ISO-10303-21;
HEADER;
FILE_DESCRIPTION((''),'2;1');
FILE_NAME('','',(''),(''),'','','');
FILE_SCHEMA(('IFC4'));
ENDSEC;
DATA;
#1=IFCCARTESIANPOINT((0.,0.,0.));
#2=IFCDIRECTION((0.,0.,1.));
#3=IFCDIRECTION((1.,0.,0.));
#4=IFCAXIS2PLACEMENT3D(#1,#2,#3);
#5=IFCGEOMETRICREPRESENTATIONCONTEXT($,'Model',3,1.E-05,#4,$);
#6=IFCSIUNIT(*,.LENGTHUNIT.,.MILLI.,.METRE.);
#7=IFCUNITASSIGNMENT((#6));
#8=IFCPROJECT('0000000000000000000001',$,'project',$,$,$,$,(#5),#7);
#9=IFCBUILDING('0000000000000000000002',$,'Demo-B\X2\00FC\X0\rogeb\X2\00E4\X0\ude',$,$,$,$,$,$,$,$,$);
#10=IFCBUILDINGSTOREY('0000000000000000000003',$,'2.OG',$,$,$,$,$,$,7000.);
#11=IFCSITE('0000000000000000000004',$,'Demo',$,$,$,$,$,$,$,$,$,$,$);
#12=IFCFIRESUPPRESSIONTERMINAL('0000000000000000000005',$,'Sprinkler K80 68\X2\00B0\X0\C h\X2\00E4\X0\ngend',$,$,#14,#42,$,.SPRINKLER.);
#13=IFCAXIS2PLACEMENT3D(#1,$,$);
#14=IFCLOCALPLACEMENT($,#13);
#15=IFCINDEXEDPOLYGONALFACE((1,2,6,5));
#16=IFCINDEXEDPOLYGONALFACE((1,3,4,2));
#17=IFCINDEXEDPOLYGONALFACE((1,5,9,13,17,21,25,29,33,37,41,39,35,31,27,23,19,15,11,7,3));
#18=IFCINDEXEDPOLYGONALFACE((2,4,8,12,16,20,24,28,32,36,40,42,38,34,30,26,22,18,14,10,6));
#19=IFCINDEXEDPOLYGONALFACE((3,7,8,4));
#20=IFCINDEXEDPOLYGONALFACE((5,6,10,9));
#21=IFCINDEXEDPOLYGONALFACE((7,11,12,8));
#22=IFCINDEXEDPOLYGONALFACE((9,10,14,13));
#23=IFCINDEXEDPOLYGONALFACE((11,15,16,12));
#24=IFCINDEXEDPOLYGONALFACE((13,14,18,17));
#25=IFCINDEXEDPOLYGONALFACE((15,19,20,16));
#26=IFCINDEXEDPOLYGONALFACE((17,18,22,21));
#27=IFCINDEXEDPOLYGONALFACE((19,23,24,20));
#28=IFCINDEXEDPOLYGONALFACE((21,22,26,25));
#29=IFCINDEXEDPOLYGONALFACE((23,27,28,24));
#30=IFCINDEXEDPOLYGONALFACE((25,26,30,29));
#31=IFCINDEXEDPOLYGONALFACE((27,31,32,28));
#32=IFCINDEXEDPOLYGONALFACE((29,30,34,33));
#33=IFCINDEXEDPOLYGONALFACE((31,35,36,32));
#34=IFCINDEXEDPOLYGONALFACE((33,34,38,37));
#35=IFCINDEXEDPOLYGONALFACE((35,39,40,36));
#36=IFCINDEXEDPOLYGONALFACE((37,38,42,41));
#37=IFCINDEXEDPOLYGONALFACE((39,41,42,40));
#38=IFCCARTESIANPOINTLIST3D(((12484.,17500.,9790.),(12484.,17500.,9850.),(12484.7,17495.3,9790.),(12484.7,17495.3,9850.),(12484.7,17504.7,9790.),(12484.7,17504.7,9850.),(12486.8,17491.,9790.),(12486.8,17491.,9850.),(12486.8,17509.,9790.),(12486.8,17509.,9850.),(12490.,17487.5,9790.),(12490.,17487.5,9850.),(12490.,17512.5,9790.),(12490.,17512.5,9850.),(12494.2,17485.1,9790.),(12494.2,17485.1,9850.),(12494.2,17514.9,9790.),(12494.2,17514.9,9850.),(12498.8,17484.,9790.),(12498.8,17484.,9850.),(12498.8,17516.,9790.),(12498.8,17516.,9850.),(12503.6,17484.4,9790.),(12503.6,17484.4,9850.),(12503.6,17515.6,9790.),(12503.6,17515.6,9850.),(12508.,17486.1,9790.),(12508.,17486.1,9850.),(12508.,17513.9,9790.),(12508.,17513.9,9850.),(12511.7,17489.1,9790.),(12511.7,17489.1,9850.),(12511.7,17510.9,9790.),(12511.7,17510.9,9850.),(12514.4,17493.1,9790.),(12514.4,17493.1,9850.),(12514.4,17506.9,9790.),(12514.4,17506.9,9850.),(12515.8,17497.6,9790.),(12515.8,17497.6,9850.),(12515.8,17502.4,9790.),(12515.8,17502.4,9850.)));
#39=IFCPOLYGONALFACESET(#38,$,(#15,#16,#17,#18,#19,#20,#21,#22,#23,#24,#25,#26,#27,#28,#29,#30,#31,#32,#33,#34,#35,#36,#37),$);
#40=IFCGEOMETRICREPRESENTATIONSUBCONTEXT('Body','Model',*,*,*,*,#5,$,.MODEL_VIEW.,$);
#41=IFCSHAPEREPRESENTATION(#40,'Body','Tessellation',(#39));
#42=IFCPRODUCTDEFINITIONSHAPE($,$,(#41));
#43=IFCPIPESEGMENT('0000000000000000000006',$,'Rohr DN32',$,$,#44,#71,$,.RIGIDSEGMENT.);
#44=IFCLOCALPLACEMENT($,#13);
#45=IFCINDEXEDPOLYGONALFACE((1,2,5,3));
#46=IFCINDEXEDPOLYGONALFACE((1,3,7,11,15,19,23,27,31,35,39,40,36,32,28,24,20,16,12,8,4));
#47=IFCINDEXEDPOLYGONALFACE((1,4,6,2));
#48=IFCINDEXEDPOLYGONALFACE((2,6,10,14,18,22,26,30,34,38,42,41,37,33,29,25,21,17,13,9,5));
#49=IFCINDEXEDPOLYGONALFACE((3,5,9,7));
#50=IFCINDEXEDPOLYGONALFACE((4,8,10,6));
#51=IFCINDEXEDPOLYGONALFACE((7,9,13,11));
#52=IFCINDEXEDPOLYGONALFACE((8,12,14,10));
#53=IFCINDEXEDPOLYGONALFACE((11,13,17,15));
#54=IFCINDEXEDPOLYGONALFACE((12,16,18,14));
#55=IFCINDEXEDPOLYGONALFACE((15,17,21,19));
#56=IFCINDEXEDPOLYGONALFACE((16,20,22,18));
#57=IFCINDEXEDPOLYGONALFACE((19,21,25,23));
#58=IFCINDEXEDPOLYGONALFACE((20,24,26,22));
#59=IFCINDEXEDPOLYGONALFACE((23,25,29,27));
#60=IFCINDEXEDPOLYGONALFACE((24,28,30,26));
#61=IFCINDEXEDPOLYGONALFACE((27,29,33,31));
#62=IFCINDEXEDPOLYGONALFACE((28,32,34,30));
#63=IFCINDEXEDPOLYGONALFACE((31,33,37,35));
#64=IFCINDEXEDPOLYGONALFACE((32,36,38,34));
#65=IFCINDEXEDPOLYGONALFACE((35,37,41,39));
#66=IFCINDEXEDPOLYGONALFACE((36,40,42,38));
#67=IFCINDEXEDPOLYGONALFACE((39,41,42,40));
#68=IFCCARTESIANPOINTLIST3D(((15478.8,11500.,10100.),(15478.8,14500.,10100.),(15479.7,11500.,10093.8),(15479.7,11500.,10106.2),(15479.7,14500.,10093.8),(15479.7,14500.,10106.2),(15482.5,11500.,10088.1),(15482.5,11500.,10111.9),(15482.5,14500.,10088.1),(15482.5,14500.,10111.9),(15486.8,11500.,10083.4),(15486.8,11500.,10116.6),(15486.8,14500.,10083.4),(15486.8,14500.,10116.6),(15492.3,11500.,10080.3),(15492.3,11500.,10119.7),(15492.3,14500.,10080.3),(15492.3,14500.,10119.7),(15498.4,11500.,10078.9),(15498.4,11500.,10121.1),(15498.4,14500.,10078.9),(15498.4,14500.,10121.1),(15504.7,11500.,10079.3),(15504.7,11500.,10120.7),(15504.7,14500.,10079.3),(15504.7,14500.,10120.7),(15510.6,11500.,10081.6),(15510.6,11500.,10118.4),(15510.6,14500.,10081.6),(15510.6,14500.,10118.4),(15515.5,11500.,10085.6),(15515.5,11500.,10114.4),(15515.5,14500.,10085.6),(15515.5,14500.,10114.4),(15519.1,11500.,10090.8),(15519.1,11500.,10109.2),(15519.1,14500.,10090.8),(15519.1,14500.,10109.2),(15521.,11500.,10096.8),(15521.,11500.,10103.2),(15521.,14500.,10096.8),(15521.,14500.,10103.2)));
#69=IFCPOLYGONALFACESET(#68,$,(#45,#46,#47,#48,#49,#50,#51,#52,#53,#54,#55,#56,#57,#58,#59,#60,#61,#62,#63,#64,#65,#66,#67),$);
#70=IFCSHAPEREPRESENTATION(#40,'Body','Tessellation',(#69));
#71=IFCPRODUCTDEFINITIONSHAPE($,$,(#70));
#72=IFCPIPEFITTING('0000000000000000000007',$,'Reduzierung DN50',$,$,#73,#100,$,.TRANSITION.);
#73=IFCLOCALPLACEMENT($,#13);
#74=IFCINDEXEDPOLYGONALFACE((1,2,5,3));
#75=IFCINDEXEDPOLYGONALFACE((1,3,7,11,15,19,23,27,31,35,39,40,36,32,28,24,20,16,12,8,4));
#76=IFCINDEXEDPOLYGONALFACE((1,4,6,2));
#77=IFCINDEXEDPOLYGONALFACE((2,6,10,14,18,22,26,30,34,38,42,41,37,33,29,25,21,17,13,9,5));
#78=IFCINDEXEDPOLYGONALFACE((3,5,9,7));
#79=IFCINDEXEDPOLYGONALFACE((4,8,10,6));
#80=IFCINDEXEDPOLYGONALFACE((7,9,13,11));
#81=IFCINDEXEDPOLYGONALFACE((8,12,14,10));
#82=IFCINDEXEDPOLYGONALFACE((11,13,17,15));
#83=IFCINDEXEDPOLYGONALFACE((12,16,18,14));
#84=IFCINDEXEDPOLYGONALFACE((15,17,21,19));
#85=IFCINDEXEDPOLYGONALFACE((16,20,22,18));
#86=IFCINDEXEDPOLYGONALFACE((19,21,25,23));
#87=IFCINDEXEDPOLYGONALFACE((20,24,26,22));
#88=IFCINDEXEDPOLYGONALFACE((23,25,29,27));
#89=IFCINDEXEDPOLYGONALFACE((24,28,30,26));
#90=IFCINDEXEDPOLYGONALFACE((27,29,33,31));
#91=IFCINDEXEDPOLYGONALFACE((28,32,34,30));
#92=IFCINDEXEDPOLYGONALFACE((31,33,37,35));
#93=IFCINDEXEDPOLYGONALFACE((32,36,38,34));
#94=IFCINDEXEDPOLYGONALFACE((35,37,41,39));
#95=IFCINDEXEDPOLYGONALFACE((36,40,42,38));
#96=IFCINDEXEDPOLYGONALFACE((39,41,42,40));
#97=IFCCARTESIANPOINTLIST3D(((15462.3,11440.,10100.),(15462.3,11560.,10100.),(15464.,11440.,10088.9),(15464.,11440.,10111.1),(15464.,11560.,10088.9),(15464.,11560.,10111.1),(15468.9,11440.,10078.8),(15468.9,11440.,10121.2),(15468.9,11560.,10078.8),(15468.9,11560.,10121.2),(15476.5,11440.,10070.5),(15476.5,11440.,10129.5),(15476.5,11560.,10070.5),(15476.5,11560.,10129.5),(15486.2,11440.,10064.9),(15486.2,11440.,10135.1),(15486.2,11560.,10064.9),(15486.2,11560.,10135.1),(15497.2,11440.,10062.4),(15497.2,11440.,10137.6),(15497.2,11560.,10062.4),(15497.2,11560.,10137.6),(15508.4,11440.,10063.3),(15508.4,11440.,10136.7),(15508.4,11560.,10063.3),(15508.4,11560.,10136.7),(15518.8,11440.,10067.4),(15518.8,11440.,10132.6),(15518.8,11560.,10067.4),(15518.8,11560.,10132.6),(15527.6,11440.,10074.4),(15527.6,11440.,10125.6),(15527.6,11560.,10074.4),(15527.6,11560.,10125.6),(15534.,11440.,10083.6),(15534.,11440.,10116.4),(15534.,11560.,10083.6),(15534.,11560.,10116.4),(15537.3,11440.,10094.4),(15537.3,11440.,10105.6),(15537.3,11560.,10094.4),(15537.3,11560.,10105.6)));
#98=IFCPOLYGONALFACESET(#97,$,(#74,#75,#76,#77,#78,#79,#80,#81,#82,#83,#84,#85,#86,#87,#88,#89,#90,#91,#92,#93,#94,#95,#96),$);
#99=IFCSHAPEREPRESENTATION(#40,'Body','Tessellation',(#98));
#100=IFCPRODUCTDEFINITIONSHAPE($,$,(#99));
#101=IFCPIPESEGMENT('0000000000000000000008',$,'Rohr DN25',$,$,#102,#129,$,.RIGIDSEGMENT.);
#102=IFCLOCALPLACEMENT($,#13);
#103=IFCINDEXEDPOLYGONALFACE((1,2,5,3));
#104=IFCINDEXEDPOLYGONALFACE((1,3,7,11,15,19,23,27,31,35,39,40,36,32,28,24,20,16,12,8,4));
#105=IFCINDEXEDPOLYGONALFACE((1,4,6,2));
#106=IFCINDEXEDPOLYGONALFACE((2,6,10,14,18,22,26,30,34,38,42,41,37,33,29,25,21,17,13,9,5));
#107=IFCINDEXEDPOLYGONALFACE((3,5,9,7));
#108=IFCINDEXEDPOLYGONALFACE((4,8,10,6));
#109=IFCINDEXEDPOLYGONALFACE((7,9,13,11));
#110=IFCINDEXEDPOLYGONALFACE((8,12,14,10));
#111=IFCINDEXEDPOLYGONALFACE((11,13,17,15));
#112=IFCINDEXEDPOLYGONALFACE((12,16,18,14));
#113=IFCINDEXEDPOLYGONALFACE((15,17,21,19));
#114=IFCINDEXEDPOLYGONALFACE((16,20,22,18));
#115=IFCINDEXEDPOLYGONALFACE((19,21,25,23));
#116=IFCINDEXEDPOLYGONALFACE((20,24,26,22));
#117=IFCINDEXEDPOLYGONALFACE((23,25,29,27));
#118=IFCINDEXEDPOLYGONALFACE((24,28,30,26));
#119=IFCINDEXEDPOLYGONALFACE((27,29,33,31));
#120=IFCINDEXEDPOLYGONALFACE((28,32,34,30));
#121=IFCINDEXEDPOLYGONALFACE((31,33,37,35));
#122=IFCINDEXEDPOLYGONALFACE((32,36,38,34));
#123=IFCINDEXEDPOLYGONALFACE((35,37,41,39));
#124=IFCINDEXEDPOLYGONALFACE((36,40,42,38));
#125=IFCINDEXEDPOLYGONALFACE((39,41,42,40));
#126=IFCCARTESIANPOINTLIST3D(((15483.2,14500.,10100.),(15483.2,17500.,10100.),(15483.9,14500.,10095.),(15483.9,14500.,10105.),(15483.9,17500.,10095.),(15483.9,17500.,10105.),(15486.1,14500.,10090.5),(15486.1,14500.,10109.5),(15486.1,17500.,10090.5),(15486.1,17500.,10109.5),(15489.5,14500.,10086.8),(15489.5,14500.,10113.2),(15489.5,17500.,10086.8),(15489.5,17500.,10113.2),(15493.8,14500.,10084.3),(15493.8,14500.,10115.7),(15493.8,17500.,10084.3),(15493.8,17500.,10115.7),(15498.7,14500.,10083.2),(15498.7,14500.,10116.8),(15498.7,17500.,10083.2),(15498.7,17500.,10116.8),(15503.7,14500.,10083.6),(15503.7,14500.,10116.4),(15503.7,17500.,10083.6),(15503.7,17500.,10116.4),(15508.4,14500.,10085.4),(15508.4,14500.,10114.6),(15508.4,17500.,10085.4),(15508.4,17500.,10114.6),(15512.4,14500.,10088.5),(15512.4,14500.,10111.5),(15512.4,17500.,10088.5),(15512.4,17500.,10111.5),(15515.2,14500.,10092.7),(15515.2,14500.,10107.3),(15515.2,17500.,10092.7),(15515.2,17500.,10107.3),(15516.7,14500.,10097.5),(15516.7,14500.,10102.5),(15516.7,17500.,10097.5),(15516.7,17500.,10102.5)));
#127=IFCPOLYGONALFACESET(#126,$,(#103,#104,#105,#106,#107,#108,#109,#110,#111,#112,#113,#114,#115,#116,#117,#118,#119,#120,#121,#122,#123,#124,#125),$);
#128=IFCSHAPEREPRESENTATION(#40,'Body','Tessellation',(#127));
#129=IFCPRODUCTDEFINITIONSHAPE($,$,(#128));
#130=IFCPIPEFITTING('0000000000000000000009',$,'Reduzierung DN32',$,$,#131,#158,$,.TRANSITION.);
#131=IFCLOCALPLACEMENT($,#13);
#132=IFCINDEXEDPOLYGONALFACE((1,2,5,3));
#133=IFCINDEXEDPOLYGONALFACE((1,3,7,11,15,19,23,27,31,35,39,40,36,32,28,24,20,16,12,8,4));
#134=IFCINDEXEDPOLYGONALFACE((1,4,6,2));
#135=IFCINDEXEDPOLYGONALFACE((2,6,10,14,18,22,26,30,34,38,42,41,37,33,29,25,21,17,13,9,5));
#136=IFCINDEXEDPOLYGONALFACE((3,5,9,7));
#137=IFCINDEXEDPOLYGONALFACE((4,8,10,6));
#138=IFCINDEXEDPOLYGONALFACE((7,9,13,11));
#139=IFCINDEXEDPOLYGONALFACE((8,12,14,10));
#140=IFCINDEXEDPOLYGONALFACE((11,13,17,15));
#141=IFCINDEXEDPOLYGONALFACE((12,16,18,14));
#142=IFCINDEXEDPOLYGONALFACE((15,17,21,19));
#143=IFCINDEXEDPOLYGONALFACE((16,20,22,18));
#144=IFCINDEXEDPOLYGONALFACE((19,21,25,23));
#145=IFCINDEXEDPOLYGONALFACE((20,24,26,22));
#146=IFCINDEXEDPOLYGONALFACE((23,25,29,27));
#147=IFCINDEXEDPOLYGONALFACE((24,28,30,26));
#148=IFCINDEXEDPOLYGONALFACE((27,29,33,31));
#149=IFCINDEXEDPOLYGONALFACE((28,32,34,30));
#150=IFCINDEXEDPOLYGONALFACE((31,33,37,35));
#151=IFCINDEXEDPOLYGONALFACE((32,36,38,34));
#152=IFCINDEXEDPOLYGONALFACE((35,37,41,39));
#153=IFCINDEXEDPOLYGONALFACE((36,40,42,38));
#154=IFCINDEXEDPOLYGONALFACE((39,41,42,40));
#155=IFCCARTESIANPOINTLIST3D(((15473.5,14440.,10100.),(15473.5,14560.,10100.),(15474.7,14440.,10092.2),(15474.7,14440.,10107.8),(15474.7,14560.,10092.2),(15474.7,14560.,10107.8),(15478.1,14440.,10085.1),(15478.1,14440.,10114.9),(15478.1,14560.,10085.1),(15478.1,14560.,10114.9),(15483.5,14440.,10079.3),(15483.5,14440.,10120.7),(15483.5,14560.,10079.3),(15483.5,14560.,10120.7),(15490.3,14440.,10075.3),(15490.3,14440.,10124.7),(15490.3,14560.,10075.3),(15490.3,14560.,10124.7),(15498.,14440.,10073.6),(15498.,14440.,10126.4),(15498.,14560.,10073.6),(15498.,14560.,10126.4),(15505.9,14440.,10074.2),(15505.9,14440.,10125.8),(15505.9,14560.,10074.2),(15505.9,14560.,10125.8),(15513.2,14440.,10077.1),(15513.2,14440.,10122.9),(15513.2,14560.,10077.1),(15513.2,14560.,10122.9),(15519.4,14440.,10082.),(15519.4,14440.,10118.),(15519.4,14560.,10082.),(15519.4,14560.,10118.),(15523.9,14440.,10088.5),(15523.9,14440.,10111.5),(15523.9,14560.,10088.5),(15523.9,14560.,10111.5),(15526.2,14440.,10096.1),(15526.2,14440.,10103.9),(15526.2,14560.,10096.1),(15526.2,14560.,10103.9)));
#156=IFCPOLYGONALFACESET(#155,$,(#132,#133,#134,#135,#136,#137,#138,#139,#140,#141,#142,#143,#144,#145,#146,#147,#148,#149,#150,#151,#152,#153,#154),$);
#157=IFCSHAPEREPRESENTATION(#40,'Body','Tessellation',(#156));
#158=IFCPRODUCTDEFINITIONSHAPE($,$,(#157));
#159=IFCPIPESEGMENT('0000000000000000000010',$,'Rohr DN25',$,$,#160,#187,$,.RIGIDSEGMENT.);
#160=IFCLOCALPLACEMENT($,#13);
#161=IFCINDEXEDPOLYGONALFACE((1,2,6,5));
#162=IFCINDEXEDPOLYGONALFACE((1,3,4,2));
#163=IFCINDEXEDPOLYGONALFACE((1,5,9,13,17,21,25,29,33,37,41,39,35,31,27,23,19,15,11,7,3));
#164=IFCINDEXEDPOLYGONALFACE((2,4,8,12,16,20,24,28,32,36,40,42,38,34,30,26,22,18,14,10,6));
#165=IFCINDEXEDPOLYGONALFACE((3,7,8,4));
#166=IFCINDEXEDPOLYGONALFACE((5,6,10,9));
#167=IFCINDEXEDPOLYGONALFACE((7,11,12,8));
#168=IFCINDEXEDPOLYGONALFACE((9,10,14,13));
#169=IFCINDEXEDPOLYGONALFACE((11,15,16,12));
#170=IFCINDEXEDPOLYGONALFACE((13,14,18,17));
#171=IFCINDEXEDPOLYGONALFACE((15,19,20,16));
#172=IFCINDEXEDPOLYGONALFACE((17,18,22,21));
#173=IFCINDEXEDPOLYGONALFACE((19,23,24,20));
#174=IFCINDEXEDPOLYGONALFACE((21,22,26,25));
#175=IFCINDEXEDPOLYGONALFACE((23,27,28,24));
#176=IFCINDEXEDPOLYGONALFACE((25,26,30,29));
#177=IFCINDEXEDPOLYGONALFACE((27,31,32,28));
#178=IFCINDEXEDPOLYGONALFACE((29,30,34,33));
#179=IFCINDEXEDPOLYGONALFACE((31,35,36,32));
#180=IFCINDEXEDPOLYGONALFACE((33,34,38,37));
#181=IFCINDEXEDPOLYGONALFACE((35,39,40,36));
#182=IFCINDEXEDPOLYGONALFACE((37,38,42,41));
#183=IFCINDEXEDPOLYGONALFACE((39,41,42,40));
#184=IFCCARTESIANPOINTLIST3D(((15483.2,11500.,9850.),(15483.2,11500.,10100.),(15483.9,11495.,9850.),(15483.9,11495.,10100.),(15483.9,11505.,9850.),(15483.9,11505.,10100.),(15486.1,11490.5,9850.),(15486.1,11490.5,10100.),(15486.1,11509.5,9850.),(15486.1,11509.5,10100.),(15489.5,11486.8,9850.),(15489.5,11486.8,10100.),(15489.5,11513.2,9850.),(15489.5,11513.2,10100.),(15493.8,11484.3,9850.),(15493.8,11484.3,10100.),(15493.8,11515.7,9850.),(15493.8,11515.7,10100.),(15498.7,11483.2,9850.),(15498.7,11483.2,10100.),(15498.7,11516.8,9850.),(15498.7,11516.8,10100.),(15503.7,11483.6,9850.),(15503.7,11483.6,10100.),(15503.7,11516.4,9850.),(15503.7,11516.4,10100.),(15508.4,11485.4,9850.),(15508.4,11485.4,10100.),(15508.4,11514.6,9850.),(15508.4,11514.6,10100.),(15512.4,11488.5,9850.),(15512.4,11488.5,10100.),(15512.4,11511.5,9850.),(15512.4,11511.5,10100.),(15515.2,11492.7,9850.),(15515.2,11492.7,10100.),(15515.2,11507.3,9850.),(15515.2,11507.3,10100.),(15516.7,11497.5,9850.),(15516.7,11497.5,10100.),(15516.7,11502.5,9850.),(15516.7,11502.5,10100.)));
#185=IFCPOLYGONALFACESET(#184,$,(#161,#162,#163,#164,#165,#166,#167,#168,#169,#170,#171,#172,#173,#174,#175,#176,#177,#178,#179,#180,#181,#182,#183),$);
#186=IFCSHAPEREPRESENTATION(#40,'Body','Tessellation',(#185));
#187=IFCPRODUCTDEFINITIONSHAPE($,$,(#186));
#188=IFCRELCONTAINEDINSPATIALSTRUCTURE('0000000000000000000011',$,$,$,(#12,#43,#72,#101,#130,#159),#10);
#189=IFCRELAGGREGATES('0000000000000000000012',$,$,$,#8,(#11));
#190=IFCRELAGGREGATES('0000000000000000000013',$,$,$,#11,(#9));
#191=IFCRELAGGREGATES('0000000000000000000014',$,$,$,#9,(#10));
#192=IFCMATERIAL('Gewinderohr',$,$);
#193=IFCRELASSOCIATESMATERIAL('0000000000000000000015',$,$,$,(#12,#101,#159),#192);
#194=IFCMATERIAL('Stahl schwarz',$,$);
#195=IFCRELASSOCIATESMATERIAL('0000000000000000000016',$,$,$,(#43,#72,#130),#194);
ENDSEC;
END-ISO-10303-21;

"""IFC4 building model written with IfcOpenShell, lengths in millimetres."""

from ifc_helpers import new_model, si_unit, frame, origin_with_axes, place, context, subcontext, project, spatial, circle, extrude, material, element, save


model = new_model("IFC4")

# Units and contexts
model_context = context("Model", 3, precision=1e-05, world=origin_with_axes())
body_context = subcontext(model_context, "Body", "Model", "MODEL_VIEW")
ifc_project = project(units=[si_unit("LENGTHUNIT", "METRE", prefix="MILLI")], contexts=[model_context])

# Site, building, storey
site = spatial("IfcSite", under=ifc_project, Name="Demo")
building = spatial("IfcBuilding", under=site, Name="Demo-Bürogebäude")
storey = spatial("IfcBuildingStorey", under=building, Name="2.OG", Elevation=7000.0)

# Shared definitions
ifc_material_1 = material(Name="Stahl schwarz")

# Shared definitions
ifc_material_2 = material(Name="Gewinderohr")

# Fire suppression terminal
fire_suppression_terminal_1_placement = place(None, frame((12500.0, 17500.0, 9850.0), z_axis=(0.0, 0.0, -1.0), x_axis=(-1.0, 0.0, 0.0)))
element("IfcFireSuppressionTerminal", 1, at=fire_suppression_terminal_1_placement, inside=storey, material=ifc_material_2, Name="Sprinkler K80 68°C hängend", PredefinedType="SPRINKLER", context=body_context, shape_type="SweptSolid", body=[
    extrude(circle(Radius=16.0), origin_with_axes(), (0.0, 0.0, 1.0), 60.0),
])

# Pipe segment
pipe_segment_1_placement = place(None, frame((15500.0, 11500.0, 10100.0), z_axis=(0.0, 1.0, 0.0), x_axis=(-1.0, 0.0, 0.0)))
element("IfcPipeSegment", 2, at=pipe_segment_1_placement, inside=storey, material=ifc_material_1, Name="Rohr DN32", PredefinedType="RIGIDSEGMENT", context=body_context, shape_type="SweptSolid", body=[
    extrude(circle(Radius=21.2), origin_with_axes(), (0.0, 0.0, 1.0), 3000.0),
])

# Pipe fitting
pipe_fitting_1_placement = place(None, frame((15500.0, 11440.0, 10100.0), z_axis=(0.0, 1.0, 0.0), x_axis=(-1.0, 0.0, 0.0)))
element("IfcPipeFitting", 3, at=pipe_fitting_1_placement, inside=storey, material=ifc_material_1, Name="Reduzierung DN50", PredefinedType="TRANSITION", context=body_context, shape_type="SweptSolid", body=[
    extrude(circle(Radius=37.7), origin_with_axes(), (0.0, 0.0, 1.0), 120.0),
])

# Pipe segment
pipe_segment_2_placement = place(None, frame((15500.0, 14500.0, 10100.0), z_axis=(0.0, 1.0, 0.0), x_axis=(-1.0, 0.0, 0.0)))
element("IfcPipeSegment", 4, at=pipe_segment_2_placement, inside=storey, material=ifc_material_2, Name="Rohr DN25", PredefinedType="RIGIDSEGMENT", context=body_context, shape_type="SweptSolid", body=[
    extrude(circle(Radius=16.9), origin_with_axes(), (0.0, 0.0, 1.0), 3000.0),
])

# Pipe fitting
pipe_fitting_2_placement = place(None, frame((15500.0, 14440.0, 10100.0), z_axis=(0.0, 1.0, 0.0), x_axis=(-1.0, 0.0, 0.0)))
element("IfcPipeFitting", 5, at=pipe_fitting_2_placement, inside=storey, material=ifc_material_1, Name="Reduzierung DN32", PredefinedType="TRANSITION", context=body_context, shape_type="SweptSolid", body=[
    extrude(circle(Radius=26.5), origin_with_axes(), (0.0, 0.0, 1.0), 120.0),
])

# Pipe segment
pipe_segment_3_placement = place(None, frame((15500.0, 11500.0, 10100.0), z_axis=(0.0, 0.0, -1.0), x_axis=(-1.0, 0.0, 0.0)))
element("IfcPipeSegment", 6, at=pipe_segment_3_placement, inside=storey, material=ifc_material_2, Name="Rohr DN25", PredefinedType="RIGIDSEGMENT", context=body_context, shape_type="SweptSolid", body=[
    extrude(circle(Radius=16.9), origin_with_axes(), (0.0, 0.0, 1.0), 250.0),
])

save(model, "model.ifc")
